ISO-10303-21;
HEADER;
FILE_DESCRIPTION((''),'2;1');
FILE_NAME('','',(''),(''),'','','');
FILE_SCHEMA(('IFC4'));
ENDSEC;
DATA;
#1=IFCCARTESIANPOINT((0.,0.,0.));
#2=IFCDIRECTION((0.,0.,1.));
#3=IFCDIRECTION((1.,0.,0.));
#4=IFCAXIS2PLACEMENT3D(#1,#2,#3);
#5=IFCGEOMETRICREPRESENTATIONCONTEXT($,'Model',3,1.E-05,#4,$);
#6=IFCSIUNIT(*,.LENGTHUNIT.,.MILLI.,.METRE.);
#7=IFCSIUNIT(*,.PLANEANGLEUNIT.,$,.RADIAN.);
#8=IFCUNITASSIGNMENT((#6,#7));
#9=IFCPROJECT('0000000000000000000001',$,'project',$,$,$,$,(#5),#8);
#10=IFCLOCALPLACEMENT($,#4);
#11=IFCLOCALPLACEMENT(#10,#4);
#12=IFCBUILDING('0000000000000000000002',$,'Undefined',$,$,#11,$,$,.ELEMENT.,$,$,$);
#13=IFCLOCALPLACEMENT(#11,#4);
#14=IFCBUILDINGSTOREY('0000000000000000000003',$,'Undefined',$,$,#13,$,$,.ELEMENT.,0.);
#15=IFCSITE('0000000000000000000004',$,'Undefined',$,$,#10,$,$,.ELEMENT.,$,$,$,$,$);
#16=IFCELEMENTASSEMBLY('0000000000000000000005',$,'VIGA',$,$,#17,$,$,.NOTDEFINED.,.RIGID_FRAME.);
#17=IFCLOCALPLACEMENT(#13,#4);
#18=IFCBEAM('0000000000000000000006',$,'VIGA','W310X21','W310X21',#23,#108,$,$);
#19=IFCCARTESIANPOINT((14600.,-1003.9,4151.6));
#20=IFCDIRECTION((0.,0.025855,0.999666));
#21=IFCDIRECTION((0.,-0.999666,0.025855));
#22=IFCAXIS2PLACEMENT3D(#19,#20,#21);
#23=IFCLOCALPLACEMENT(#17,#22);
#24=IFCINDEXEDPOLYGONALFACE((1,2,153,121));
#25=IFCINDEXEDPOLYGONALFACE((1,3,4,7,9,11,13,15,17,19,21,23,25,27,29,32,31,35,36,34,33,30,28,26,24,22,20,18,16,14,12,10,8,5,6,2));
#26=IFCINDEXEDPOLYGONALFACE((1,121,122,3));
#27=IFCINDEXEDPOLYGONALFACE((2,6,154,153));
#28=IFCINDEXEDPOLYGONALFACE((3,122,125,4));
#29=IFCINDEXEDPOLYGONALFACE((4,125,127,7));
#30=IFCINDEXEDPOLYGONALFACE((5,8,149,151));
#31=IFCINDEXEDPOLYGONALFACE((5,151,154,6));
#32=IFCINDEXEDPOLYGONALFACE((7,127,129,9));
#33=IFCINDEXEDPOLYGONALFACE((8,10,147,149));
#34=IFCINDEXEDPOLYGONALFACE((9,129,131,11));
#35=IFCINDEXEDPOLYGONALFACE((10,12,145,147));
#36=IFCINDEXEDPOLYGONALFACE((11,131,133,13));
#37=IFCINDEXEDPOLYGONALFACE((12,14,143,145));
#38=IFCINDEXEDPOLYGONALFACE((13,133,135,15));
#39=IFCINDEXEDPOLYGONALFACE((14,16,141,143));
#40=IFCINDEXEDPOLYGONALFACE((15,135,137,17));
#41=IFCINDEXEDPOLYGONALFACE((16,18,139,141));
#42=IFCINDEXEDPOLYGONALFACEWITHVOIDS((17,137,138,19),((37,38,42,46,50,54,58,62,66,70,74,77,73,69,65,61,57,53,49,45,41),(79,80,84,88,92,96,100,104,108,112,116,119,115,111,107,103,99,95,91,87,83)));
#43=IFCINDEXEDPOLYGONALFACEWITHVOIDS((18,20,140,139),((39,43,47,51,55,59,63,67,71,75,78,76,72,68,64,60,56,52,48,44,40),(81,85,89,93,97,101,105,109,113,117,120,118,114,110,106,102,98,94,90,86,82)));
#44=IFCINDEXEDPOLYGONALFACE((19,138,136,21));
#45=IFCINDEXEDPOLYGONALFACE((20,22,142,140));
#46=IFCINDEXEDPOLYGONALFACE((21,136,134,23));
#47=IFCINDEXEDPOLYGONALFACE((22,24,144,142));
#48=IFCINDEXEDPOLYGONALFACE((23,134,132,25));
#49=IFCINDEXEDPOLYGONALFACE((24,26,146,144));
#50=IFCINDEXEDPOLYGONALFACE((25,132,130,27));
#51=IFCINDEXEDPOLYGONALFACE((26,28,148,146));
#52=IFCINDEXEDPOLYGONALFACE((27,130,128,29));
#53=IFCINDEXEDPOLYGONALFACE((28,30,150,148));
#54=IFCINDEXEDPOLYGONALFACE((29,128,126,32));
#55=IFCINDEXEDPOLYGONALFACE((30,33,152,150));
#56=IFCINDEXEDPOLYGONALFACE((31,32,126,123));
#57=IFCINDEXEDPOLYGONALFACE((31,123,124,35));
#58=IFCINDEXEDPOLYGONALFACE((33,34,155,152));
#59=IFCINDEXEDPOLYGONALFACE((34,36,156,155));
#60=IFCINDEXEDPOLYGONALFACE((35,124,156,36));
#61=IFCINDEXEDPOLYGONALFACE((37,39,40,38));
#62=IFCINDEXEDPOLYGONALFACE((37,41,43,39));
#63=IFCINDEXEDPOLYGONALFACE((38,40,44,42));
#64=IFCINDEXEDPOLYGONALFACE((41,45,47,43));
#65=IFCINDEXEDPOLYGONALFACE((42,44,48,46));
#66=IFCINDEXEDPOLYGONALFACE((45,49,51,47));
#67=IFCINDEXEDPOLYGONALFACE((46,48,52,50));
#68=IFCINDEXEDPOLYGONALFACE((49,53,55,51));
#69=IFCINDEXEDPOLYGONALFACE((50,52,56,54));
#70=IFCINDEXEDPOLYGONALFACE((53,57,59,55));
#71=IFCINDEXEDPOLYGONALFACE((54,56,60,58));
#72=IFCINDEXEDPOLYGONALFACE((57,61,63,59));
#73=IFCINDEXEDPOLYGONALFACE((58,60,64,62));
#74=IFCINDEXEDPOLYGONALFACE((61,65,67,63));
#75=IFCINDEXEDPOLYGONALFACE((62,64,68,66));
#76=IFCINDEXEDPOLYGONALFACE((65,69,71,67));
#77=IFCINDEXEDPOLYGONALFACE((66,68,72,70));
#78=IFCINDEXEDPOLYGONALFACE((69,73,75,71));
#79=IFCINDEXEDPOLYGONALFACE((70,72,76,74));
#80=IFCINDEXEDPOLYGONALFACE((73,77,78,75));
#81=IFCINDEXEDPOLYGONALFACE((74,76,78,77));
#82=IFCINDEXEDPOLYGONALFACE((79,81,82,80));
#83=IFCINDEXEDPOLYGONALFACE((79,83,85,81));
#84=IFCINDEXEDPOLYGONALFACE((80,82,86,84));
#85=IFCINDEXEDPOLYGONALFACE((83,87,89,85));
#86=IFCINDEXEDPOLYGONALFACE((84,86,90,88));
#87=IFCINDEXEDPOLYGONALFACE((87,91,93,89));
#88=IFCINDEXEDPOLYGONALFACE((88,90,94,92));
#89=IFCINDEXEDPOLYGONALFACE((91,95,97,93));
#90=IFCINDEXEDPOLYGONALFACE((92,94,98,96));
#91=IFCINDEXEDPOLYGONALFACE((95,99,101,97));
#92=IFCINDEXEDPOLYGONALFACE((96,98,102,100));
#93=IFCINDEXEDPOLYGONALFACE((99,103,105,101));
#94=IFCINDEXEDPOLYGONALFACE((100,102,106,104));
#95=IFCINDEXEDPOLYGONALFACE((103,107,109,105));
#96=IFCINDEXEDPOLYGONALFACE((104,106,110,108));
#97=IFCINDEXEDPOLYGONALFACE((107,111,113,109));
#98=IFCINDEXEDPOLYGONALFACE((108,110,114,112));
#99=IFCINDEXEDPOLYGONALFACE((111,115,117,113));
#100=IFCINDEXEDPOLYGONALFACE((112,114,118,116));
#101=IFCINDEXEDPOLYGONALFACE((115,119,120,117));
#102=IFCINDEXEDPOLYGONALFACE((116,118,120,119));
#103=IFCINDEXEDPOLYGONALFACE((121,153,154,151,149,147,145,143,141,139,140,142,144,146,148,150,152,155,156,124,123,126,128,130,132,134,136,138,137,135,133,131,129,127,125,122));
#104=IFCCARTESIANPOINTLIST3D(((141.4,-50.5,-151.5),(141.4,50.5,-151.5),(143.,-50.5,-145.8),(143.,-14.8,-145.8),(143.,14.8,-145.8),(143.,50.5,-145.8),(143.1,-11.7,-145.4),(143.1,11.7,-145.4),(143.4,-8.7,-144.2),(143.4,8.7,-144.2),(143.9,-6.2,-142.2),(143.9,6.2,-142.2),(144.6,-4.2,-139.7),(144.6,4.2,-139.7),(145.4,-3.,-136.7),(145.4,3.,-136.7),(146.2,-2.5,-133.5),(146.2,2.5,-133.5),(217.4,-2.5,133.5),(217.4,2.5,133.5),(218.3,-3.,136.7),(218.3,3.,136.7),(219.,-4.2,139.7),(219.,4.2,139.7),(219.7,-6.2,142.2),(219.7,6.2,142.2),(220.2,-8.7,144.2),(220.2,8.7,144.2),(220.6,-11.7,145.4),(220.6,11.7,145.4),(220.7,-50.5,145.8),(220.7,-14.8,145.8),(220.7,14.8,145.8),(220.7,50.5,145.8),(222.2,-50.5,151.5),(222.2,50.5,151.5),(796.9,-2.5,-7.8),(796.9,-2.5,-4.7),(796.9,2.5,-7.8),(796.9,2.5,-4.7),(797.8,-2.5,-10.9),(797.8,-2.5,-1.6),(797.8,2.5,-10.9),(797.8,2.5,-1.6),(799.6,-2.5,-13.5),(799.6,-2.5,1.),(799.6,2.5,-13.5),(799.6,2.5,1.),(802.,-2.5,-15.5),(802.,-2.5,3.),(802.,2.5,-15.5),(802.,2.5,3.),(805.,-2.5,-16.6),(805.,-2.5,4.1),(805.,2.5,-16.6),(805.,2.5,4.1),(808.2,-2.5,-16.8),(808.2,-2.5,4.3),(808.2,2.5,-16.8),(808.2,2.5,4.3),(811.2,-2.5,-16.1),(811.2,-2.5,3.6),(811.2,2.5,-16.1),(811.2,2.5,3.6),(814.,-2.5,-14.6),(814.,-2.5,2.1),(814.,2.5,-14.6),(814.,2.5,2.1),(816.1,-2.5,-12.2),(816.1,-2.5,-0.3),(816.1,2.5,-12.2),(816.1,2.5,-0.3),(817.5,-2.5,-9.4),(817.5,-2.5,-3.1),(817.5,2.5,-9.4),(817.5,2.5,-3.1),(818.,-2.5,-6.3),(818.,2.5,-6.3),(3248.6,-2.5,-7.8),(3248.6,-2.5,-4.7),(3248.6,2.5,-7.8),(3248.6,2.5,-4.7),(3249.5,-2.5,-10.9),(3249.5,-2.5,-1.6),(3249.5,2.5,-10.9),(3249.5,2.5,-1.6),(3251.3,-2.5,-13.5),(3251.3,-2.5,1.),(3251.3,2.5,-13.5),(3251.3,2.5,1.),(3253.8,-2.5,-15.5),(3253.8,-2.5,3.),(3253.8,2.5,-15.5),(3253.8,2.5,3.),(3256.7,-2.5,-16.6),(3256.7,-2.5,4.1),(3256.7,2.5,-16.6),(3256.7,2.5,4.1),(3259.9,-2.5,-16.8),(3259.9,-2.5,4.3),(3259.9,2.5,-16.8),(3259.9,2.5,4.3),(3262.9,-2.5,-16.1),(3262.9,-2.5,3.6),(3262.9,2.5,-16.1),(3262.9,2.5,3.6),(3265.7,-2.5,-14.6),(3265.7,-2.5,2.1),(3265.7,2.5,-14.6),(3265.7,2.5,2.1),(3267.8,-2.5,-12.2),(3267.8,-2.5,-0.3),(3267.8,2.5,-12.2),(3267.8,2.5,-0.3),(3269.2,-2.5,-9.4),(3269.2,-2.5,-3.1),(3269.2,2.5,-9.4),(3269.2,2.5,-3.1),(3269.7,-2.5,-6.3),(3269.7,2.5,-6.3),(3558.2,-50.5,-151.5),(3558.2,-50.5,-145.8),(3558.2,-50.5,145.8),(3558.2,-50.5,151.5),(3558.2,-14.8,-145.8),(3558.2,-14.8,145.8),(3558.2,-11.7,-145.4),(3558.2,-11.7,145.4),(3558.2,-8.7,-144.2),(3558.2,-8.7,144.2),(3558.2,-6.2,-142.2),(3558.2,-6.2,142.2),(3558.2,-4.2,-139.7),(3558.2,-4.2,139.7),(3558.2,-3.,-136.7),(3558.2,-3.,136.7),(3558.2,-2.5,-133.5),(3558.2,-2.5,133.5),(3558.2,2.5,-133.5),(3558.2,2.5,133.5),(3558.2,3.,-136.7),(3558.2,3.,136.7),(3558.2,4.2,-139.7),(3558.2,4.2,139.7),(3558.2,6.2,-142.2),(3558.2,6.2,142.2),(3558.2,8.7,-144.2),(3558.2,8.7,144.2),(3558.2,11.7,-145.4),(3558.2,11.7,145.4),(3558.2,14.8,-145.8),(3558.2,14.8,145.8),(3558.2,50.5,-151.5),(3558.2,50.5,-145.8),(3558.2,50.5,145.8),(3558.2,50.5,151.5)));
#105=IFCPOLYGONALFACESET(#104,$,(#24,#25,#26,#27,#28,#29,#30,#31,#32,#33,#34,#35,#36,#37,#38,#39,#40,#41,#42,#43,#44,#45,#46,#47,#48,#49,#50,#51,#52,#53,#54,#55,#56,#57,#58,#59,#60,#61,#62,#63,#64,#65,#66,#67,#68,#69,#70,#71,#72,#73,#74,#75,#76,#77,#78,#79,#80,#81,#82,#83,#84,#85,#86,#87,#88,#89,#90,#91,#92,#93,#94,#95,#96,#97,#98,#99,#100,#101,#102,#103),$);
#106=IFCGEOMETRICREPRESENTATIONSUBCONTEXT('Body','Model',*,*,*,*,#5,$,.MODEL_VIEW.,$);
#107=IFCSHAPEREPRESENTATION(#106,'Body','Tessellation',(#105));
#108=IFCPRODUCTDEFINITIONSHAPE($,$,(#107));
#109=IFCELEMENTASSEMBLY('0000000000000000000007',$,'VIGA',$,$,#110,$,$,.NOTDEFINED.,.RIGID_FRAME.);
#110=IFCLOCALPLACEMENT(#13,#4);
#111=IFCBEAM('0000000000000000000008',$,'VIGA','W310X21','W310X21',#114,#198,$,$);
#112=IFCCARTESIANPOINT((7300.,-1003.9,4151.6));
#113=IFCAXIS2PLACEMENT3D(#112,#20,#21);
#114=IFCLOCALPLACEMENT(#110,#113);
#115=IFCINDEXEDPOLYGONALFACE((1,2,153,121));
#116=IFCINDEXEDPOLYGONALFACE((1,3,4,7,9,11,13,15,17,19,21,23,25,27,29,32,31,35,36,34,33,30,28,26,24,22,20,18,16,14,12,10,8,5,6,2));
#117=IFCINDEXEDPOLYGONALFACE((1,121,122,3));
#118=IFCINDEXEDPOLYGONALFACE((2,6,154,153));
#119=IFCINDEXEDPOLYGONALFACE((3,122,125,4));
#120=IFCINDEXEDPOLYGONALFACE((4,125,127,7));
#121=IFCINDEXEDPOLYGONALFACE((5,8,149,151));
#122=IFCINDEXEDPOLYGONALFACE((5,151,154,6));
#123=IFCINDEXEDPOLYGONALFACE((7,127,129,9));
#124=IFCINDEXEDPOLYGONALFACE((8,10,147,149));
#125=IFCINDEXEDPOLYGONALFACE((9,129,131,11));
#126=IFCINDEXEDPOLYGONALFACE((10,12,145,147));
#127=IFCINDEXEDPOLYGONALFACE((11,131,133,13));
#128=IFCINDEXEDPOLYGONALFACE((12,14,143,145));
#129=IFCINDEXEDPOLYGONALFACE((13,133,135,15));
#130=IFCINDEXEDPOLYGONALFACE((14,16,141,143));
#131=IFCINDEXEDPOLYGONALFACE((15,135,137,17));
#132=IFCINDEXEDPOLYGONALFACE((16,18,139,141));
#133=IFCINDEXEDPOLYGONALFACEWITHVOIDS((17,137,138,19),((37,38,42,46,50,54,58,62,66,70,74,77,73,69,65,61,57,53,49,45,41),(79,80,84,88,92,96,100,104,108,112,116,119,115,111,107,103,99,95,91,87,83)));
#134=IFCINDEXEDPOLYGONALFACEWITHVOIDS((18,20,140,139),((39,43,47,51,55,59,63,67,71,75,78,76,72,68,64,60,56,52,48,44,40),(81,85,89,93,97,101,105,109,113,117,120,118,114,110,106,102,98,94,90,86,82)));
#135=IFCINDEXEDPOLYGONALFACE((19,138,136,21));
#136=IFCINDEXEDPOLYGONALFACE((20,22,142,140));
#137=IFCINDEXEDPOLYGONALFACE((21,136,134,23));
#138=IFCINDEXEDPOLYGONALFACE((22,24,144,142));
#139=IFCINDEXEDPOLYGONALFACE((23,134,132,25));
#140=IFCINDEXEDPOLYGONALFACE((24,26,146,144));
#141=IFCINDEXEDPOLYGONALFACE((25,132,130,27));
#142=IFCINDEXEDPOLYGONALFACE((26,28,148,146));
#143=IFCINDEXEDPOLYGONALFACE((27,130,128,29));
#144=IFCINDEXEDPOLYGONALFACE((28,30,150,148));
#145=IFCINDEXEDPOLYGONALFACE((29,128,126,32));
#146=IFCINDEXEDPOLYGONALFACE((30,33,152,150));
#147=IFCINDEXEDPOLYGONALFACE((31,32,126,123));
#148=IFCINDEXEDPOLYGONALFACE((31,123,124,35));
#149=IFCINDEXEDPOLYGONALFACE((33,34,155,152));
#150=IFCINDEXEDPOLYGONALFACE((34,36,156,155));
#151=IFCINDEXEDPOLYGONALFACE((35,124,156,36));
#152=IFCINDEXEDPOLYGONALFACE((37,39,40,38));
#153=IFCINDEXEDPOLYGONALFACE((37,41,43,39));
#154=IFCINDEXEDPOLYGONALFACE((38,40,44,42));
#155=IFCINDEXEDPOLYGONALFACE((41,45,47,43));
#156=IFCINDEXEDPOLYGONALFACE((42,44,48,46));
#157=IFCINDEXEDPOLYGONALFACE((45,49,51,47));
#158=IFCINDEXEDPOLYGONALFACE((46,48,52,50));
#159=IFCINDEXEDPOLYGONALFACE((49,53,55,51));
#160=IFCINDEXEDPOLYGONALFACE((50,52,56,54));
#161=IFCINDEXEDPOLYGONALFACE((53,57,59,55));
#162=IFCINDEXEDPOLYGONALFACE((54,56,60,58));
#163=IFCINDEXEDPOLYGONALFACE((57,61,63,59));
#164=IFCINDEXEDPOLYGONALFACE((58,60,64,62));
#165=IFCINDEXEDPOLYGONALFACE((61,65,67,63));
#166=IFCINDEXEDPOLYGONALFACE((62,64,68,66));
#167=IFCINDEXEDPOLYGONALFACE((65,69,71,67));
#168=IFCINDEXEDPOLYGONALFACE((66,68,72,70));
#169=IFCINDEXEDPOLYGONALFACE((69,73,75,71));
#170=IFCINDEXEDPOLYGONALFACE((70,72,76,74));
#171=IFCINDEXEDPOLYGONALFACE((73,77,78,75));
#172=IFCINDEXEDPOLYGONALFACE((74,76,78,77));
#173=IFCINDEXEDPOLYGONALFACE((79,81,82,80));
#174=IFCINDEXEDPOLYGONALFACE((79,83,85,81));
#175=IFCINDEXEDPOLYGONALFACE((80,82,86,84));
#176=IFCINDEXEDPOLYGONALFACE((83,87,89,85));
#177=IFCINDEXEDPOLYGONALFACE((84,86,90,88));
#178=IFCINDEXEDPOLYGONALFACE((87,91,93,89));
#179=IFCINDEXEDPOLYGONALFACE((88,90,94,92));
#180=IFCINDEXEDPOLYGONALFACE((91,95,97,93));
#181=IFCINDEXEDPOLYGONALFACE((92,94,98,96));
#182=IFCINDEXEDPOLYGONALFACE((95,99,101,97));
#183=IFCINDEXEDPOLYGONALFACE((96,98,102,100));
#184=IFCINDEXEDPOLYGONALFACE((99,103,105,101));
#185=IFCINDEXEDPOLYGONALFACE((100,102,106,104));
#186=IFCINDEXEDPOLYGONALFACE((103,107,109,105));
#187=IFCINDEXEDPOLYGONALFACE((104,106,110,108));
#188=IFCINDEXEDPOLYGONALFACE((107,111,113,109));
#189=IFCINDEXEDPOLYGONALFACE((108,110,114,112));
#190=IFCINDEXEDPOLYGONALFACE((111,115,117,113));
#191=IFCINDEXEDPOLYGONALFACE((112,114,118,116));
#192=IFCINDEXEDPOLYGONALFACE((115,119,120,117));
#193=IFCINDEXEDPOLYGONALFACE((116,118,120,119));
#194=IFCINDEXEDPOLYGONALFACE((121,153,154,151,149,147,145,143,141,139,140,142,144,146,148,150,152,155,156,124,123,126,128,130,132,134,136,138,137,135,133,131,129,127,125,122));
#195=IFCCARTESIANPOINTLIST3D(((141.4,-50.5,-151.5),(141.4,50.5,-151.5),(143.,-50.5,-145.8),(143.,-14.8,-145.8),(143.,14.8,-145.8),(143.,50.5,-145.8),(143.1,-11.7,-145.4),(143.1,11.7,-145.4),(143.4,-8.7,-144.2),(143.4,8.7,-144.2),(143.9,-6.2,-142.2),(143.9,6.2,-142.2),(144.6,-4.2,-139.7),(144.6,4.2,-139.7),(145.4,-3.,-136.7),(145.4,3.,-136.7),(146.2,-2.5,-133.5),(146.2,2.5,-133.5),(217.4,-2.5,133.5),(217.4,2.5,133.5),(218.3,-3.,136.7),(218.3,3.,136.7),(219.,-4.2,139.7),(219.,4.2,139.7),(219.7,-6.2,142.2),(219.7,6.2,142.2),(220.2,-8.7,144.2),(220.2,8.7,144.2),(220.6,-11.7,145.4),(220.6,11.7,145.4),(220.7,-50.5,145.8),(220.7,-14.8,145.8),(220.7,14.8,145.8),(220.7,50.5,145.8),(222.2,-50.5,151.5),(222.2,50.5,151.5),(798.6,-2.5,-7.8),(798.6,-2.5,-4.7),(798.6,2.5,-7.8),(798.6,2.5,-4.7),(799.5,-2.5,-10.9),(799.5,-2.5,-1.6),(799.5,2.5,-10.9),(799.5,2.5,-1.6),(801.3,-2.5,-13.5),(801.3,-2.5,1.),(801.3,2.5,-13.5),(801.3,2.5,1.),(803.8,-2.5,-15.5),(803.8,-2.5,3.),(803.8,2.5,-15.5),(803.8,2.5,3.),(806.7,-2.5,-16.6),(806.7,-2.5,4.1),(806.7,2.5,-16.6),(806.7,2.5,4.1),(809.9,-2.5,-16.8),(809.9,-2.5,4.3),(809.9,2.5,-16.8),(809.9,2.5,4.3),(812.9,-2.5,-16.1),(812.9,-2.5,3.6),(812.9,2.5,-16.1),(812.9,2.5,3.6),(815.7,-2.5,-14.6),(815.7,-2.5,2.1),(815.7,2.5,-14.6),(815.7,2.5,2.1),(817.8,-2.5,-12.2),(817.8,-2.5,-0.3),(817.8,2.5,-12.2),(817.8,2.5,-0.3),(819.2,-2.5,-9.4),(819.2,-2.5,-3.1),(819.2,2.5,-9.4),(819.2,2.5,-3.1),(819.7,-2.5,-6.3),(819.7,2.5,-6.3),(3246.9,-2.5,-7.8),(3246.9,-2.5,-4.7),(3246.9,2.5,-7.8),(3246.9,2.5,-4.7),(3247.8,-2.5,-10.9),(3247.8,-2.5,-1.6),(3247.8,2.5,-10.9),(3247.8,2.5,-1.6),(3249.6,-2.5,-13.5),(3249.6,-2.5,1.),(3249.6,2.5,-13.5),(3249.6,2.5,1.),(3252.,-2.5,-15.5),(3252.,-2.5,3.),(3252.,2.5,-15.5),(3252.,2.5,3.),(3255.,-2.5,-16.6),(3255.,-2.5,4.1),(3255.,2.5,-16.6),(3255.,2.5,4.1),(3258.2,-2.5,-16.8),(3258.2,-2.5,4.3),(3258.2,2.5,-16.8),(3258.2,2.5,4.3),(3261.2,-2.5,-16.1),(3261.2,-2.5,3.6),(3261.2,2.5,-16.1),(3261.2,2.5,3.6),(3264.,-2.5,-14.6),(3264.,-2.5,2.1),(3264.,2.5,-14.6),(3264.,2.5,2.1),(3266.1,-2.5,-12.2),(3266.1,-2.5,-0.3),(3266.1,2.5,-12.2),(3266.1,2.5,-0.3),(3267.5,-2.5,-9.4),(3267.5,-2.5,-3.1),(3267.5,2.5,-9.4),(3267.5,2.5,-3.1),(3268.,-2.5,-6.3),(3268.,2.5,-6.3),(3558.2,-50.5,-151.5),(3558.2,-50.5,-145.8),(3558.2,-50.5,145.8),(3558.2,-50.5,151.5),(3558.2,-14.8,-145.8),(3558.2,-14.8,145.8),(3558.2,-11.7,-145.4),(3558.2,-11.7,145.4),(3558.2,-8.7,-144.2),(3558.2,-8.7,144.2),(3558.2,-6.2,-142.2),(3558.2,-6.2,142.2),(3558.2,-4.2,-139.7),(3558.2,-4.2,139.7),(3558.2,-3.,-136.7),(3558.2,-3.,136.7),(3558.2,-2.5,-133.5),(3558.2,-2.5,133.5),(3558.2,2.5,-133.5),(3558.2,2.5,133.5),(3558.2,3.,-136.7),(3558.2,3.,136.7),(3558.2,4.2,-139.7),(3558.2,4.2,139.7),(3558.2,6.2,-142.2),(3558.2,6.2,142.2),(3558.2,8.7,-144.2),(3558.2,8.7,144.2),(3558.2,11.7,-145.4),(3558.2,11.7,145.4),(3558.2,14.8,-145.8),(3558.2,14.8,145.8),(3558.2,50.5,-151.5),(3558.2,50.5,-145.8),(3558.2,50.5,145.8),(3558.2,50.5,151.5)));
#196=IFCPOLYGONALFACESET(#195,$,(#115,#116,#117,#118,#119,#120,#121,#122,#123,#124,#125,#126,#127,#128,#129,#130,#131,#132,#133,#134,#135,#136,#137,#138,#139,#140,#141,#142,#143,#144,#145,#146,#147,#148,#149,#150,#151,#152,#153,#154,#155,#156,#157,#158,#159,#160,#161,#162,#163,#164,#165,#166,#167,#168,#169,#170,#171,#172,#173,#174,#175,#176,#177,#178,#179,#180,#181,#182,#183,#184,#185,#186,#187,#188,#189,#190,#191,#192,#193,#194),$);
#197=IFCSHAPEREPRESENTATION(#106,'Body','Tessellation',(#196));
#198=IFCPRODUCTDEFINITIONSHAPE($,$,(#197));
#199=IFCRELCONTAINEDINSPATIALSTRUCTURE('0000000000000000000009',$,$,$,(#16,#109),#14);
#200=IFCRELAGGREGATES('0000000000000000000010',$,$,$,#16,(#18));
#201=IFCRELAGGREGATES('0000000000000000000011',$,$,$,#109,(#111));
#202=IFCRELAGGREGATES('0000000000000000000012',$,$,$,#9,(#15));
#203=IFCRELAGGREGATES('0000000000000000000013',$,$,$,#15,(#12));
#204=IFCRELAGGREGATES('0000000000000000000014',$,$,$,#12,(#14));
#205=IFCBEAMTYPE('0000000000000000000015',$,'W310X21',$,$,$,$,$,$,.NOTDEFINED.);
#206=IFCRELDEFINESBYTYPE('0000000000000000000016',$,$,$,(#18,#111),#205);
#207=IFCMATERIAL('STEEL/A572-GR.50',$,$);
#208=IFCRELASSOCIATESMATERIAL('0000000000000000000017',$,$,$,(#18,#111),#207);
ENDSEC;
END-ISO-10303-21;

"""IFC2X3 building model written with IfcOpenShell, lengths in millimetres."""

from ifc_helpers import new_model, si_unit, frame, origin_with_axes, origin_2d_with_axis, place, context, subcontext, project, spatial, circle, i_section, extrude, boolean, halfspace, material, type_object, element, aggregate, save


model = new_model("IFC2X3")

# Units and contexts
model_context = context("Model", 3, precision=1e-05, world=origin_with_axes())
body_context = subcontext(model_context, "Body", "Model", "MODEL_VIEW")
ifc_project = project(units=[si_unit("LENGTHUNIT", "METRE", prefix="MILLI"), si_unit("PLANEANGLEUNIT", "RADIAN")], contexts=[model_context])

# Site, building, storey
site_placement = place(None, origin_with_axes())
site = spatial("IfcSite", under=ifc_project, at=site_placement, Name="Undefined", CompositionType="ELEMENT")
building_placement = place(site_placement, origin_with_axes())
building = spatial("IfcBuilding", under=site, at=building_placement, Name="Undefined", CompositionType="ELEMENT")
storey_placement = place(building_placement, origin_with_axes())
storey = spatial("IfcBuildingStorey", under=building, at=storey_placement, Name="Undefined", CompositionType="ELEMENT", Elevation=0.0)

# Element assemblies, beams
ifc_material_1 = material(Name="STEEL/A572-GR.50")
assembly_1_placement = place(storey_placement, origin_with_axes())
assembly_1 = element("IfcElementAssembly", 1, at=assembly_1_placement, inside=storey, Name="VIGA", AssemblyPlace="NOTDEFINED", PredefinedType="RIGID_FRAME")
beam_type_1 = type_object("IfcBeamType", Name="W310X21", PredefinedType="NOTDEFINED")
beam_1_placement = place(assembly_1_placement, frame((14600.0, -1003.9, 4151.6), z_axis=(0.0, 0.025855, 0.999666), x_axis=(0.0, -0.999666, 0.025855)))
beam_1 = element("IfcBeam", 2, at=beam_1_placement, type_object=beam_type_1, material=ifc_material_1, Name="VIGA", Description="W310X21", ObjectType="W310X21", context=body_context, shape_type="CSG", body=[
    boolean("DIFFERENCE", boolean("DIFFERENCE", boolean("DIFFERENCE", extrude(i_section(OverallWidth=101.0, OverallDepth=303.0, WebThickness=5.1, FlangeThickness=5.7, FilletRadius=12.3, at=origin_2d_with_axis()), frame((3558.2, 0.0, 0.0), z_axis=(-1.0, 0.0, 0.0), x_axis=(0.0, -1.0, 0.0)), (0.0, 0.0, 1.0), 3558.2), extrude(circle(Radius=10.6, at=origin_2d_with_axis()), frame((3259.1, 100.0, -6.3), z_axis=(0.0, -1.0, 0.0), x_axis=(1.0, 0.0, 0.0)), (0.0, 0.0, 1.0), 200.0)), extrude(circle(Radius=10.6, at=origin_2d_with_axis()), frame((807.4, 100.0, -6.3), z_axis=(0.0, -1.0, 0.0), x_axis=(1.0, 0.0, 0.0)), (0.0, 0.0, 1.0), 200.0)), halfspace(frame((141.4, 50.5, -151.7), z_axis=(-0.966259, 0.0, 0.257573), x_axis=(0.257573, 0.0, 0.966259)), False)),
])
aggregate(assembly_1, [beam_1])
assembly_2_placement = place(storey_placement, origin_with_axes())
assembly_2 = element("IfcElementAssembly", 3, at=assembly_2_placement, inside=storey, Name="VIGA", AssemblyPlace="NOTDEFINED", PredefinedType="RIGID_FRAME")
beam_2_placement = place(assembly_2_placement, frame((7300.0, -1003.9, 4151.6), z_axis=(0.0, 0.025855, 0.999666), x_axis=(0.0, -0.999666, 0.025855)))
beam_2 = element("IfcBeam", 4, at=beam_2_placement, type_object=beam_type_1, material=ifc_material_1, Name="VIGA", Description="W310X21", ObjectType="W310X21", context=body_context, shape_type="CSG", body=[
    boolean("DIFFERENCE", boolean("DIFFERENCE", boolean("DIFFERENCE", extrude(i_section(OverallWidth=101.0, OverallDepth=303.0, WebThickness=5.1, FlangeThickness=5.7, FilletRadius=12.3, at=origin_2d_with_axis()), frame((3558.2, 0.0, 0.0), z_axis=(-1.0, 0.0, 0.0), x_axis=(0.0, -1.0, 0.0)), (0.0, 0.0, 1.0), 3558.2), extrude(circle(Radius=10.6, at=origin_2d_with_axis()), frame((3257.4, -100.0, -6.3), z_axis=(0.0, 1.0, 0.0), x_axis=(1.0, 0.0, 0.0)), (0.0, 0.0, 1.0), 200.0)), extrude(circle(Radius=10.6, at=origin_2d_with_axis()), frame((809.1, -100.0, -6.3), z_axis=(0.0, 1.0, 0.0), x_axis=(1.0, 0.0, 0.0)), (0.0, 0.0, 1.0), 200.0)), halfspace(frame((141.4, 50.5, -151.7), z_axis=(-0.966259, 0.0, 0.257573), x_axis=(0.257573, 0.0, 0.966259)), False)),
])
aggregate(assembly_2, [beam_2])

save(model, "model.ifc")
